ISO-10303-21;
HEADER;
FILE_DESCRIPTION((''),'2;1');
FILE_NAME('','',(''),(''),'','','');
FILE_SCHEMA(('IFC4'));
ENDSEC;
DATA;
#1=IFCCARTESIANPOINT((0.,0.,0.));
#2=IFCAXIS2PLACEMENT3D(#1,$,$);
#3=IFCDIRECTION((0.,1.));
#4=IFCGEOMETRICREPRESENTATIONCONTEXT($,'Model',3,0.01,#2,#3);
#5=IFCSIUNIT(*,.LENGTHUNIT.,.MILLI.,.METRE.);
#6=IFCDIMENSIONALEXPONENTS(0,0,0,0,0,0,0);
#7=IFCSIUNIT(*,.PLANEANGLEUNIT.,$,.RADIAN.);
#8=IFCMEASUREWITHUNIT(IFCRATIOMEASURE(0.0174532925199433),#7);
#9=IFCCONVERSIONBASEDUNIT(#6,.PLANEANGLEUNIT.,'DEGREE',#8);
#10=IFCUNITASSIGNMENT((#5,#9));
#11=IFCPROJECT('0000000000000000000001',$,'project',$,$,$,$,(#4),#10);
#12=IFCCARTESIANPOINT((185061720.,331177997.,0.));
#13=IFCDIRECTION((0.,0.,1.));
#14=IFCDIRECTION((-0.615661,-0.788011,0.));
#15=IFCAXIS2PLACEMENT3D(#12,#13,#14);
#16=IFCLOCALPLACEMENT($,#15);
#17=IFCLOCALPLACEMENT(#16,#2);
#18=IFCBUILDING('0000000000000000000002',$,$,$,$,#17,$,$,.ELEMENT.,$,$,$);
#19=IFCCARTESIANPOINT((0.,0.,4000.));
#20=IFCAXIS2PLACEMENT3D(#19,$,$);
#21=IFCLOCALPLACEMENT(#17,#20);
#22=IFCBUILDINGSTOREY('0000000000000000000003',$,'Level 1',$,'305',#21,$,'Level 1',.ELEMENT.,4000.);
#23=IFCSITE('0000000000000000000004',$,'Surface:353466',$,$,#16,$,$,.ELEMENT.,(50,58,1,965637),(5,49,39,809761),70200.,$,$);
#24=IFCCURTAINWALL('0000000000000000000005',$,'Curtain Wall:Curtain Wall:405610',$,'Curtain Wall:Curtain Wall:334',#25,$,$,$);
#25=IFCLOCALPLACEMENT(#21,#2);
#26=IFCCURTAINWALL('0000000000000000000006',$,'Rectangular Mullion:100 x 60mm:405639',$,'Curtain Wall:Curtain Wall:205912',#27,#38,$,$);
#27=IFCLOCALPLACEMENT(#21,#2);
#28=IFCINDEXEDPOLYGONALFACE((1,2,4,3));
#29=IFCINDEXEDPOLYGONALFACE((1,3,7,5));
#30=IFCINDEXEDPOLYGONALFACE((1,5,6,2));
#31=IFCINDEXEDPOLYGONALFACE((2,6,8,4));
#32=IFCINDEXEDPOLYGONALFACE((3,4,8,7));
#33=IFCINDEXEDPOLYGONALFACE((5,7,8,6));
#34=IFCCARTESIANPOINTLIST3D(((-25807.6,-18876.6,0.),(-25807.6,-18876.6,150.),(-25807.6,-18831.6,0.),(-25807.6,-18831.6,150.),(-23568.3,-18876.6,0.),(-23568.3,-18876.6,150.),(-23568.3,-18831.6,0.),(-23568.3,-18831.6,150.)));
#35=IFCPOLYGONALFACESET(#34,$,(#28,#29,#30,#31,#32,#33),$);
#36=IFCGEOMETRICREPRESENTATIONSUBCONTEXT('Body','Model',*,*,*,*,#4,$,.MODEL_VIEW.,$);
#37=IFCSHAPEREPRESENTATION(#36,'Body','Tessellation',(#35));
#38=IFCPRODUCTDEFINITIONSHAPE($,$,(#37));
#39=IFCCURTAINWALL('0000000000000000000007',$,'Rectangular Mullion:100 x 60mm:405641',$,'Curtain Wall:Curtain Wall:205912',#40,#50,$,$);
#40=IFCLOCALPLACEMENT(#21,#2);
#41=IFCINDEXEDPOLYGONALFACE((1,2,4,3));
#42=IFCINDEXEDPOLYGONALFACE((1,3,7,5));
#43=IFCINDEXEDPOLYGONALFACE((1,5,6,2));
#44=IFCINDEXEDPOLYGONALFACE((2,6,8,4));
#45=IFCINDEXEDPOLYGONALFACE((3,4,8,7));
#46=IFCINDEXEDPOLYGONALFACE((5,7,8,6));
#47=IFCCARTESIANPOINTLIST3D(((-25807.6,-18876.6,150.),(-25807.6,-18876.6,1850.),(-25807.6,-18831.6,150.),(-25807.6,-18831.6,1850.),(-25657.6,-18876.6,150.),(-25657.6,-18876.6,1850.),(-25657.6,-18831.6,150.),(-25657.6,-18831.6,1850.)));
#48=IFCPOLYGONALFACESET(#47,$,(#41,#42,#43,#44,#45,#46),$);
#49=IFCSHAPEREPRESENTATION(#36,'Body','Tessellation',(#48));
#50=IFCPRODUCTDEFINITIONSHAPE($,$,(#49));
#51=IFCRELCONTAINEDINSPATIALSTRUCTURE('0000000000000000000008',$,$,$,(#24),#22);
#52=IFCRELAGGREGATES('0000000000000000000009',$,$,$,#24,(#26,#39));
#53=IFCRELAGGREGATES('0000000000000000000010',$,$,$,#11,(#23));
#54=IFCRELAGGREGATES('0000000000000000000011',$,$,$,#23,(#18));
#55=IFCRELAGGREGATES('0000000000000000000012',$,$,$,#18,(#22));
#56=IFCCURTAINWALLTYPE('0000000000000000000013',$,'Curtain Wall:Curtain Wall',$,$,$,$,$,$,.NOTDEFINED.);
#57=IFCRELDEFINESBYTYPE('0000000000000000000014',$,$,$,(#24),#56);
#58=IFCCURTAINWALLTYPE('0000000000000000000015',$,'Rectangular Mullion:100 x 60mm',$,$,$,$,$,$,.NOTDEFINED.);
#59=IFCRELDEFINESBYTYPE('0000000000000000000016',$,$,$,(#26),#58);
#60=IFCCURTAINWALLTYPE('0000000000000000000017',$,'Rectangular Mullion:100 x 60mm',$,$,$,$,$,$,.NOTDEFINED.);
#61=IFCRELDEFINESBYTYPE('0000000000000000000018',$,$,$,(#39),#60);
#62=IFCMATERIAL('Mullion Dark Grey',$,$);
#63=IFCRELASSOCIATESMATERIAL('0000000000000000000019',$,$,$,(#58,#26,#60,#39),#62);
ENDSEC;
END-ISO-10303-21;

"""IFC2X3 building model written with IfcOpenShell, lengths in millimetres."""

from ifc_helpers import new_model, entity, si_unit, converted_unit, direction, frame, frame_2d, origin, place, context, subcontext, project, spatial, rectangle, extrude, source, transform, mapped, material, type_object, type_shapes, element, aggregate, save


model = new_model("IFC2X3")

# Units and contexts
model_context = context("Model", 3, precision=0.01, world=origin(), true_north=direction((0.0, 1.0)))
body_context = subcontext(model_context, "Body", "Model", "MODEL_VIEW")
ifc_project = project(units=[si_unit("LENGTHUNIT", "METRE", prefix="MILLI"), converted_unit("PLANEANGLEUNIT", "DEGREE", entity("IfcRatioMeasure", 0.0174532925199433), si_unit("PLANEANGLEUNIT", "RADIAN"), dimensions=[0, 0, 0, 0, 0, 0, 0])], contexts=[model_context])

# Site, building, storey
site_placement = place(None, frame((185061720.0, 331177997.0, 0.0), z_axis=(0.0, 0.0, 1.0), x_axis=(-0.615661, -0.788011, 0.0)))
site = spatial("IfcSite", under=ifc_project, at=site_placement, Name="Surface:353466", CompositionType="ELEMENT", RefLatitude=(50, 58, 1, 965637), RefLongitude=(5, 49, 39, 809761), RefElevation=70200.0)
building_placement = place(site_placement, origin())
building = spatial("IfcBuilding", under=site, at=building_placement, CompositionType="ELEMENT")
storey_placement = place(building_placement, frame((0.0, 0.0, 4000.0)))
storey = spatial("IfcBuildingStorey", under=building, at=storey_placement, Name="Level 1", ObjectType="305", LongName="Level 1", CompositionType="ELEMENT", Elevation=4000.0)

# Curtain walls
curtain_wall_type_1 = type_object("IfcCurtainWallType", Name="Curtain Wall:Curtain Wall", PredefinedType="NOTDEFINED")
curtain_wall_1_placement = place(storey_placement, frame((0.0, 0.0, -4000.0)))
curtain_wall_1 = element("IfcCurtainWall", 1, at=curtain_wall_1_placement, inside=storey, type_object=curtain_wall_type_1, Name="Curtain Wall:Curtain Wall:405610", ObjectType="Curtain Wall:Curtain Wall:334")
ifc_material_1 = material(Name="Mullion Dark Grey")
curtain_wall_type_2 = type_object("IfcCurtainWallType", Name="Rectangular Mullion:100 x 60mm", PredefinedType="NOTDEFINED", material=ifc_material_1)
shared_shape_1 = source(origin(), body_context, "Body", "SweptSolid", [
    extrude(rectangle(XDim=45.0, YDim=150.0, at=frame_2d((0.0, 0.0), x_axis=(1.0, 0.0))), frame((-75.0, -7.5, -2239.3), z_axis=(0.0, 0.0, 1.0), x_axis=(0.0, 1.0, 0.0)), (0.0, 0.0, 1.0), 2239.3),
])
type_shapes(curtain_wall_type_2, [shared_shape_1])
curtain_wall_2_placement = place(storey_placement, frame((-25807.6, -18861.6, 0.0), z_axis=(-1.0, 0.0, 0.0), x_axis=(0.0, 0.0, -1.0)))
curtain_wall_2 = element("IfcCurtainWall", 2, at=curtain_wall_2_placement, type_object=curtain_wall_type_2, material=ifc_material_1, Name="Rectangular Mullion:100 x 60mm:405639", ObjectType="Curtain Wall:Curtain Wall:205912", context=body_context, shape_type="MappedRepresentation", body=[
    mapped(shared_shape_1, transform((0.0, 0.0, 0.0), scale=1.0)),
])
curtain_wall_type_3 = type_object("IfcCurtainWallType", Name="Rectangular Mullion:100 x 60mm", PredefinedType="NOTDEFINED", material=ifc_material_1)
shared_shape_2 = source(origin(), body_context, "Body", "SweptSolid", [
    extrude(rectangle(XDim=45.0, YDim=150.0, at=frame_2d((0.0, 0.0), x_axis=(1.0, 0.0))), frame((-75.0, -7.5, -1700.0), z_axis=(0.0, 0.0, 1.0), x_axis=(0.0, 1.0, 0.0)), (0.0, 0.0, 1.0), 1700.0),
])
type_shapes(curtain_wall_type_3, [shared_shape_2])
curtain_wall_3_placement = place(storey_placement, frame((-25807.6, -18861.6, 1850.0), z_axis=(0.0, 0.0, 1.0), x_axis=(-1.0, 0.0, 0.0)))
curtain_wall_3 = element("IfcCurtainWall", 3, at=curtain_wall_3_placement, type_object=curtain_wall_type_3, material=ifc_material_1, Name="Rectangular Mullion:100 x 60mm:405641", ObjectType="Curtain Wall:Curtain Wall:205912", context=body_context, shape_type="MappedRepresentation", body=[
    mapped(shared_shape_2, transform((0.0, 0.0, 0.0), scale=1.0)),
])
aggregate(curtain_wall_1, [curtain_wall_2, curtain_wall_3])

save(model, "model.ifc")
